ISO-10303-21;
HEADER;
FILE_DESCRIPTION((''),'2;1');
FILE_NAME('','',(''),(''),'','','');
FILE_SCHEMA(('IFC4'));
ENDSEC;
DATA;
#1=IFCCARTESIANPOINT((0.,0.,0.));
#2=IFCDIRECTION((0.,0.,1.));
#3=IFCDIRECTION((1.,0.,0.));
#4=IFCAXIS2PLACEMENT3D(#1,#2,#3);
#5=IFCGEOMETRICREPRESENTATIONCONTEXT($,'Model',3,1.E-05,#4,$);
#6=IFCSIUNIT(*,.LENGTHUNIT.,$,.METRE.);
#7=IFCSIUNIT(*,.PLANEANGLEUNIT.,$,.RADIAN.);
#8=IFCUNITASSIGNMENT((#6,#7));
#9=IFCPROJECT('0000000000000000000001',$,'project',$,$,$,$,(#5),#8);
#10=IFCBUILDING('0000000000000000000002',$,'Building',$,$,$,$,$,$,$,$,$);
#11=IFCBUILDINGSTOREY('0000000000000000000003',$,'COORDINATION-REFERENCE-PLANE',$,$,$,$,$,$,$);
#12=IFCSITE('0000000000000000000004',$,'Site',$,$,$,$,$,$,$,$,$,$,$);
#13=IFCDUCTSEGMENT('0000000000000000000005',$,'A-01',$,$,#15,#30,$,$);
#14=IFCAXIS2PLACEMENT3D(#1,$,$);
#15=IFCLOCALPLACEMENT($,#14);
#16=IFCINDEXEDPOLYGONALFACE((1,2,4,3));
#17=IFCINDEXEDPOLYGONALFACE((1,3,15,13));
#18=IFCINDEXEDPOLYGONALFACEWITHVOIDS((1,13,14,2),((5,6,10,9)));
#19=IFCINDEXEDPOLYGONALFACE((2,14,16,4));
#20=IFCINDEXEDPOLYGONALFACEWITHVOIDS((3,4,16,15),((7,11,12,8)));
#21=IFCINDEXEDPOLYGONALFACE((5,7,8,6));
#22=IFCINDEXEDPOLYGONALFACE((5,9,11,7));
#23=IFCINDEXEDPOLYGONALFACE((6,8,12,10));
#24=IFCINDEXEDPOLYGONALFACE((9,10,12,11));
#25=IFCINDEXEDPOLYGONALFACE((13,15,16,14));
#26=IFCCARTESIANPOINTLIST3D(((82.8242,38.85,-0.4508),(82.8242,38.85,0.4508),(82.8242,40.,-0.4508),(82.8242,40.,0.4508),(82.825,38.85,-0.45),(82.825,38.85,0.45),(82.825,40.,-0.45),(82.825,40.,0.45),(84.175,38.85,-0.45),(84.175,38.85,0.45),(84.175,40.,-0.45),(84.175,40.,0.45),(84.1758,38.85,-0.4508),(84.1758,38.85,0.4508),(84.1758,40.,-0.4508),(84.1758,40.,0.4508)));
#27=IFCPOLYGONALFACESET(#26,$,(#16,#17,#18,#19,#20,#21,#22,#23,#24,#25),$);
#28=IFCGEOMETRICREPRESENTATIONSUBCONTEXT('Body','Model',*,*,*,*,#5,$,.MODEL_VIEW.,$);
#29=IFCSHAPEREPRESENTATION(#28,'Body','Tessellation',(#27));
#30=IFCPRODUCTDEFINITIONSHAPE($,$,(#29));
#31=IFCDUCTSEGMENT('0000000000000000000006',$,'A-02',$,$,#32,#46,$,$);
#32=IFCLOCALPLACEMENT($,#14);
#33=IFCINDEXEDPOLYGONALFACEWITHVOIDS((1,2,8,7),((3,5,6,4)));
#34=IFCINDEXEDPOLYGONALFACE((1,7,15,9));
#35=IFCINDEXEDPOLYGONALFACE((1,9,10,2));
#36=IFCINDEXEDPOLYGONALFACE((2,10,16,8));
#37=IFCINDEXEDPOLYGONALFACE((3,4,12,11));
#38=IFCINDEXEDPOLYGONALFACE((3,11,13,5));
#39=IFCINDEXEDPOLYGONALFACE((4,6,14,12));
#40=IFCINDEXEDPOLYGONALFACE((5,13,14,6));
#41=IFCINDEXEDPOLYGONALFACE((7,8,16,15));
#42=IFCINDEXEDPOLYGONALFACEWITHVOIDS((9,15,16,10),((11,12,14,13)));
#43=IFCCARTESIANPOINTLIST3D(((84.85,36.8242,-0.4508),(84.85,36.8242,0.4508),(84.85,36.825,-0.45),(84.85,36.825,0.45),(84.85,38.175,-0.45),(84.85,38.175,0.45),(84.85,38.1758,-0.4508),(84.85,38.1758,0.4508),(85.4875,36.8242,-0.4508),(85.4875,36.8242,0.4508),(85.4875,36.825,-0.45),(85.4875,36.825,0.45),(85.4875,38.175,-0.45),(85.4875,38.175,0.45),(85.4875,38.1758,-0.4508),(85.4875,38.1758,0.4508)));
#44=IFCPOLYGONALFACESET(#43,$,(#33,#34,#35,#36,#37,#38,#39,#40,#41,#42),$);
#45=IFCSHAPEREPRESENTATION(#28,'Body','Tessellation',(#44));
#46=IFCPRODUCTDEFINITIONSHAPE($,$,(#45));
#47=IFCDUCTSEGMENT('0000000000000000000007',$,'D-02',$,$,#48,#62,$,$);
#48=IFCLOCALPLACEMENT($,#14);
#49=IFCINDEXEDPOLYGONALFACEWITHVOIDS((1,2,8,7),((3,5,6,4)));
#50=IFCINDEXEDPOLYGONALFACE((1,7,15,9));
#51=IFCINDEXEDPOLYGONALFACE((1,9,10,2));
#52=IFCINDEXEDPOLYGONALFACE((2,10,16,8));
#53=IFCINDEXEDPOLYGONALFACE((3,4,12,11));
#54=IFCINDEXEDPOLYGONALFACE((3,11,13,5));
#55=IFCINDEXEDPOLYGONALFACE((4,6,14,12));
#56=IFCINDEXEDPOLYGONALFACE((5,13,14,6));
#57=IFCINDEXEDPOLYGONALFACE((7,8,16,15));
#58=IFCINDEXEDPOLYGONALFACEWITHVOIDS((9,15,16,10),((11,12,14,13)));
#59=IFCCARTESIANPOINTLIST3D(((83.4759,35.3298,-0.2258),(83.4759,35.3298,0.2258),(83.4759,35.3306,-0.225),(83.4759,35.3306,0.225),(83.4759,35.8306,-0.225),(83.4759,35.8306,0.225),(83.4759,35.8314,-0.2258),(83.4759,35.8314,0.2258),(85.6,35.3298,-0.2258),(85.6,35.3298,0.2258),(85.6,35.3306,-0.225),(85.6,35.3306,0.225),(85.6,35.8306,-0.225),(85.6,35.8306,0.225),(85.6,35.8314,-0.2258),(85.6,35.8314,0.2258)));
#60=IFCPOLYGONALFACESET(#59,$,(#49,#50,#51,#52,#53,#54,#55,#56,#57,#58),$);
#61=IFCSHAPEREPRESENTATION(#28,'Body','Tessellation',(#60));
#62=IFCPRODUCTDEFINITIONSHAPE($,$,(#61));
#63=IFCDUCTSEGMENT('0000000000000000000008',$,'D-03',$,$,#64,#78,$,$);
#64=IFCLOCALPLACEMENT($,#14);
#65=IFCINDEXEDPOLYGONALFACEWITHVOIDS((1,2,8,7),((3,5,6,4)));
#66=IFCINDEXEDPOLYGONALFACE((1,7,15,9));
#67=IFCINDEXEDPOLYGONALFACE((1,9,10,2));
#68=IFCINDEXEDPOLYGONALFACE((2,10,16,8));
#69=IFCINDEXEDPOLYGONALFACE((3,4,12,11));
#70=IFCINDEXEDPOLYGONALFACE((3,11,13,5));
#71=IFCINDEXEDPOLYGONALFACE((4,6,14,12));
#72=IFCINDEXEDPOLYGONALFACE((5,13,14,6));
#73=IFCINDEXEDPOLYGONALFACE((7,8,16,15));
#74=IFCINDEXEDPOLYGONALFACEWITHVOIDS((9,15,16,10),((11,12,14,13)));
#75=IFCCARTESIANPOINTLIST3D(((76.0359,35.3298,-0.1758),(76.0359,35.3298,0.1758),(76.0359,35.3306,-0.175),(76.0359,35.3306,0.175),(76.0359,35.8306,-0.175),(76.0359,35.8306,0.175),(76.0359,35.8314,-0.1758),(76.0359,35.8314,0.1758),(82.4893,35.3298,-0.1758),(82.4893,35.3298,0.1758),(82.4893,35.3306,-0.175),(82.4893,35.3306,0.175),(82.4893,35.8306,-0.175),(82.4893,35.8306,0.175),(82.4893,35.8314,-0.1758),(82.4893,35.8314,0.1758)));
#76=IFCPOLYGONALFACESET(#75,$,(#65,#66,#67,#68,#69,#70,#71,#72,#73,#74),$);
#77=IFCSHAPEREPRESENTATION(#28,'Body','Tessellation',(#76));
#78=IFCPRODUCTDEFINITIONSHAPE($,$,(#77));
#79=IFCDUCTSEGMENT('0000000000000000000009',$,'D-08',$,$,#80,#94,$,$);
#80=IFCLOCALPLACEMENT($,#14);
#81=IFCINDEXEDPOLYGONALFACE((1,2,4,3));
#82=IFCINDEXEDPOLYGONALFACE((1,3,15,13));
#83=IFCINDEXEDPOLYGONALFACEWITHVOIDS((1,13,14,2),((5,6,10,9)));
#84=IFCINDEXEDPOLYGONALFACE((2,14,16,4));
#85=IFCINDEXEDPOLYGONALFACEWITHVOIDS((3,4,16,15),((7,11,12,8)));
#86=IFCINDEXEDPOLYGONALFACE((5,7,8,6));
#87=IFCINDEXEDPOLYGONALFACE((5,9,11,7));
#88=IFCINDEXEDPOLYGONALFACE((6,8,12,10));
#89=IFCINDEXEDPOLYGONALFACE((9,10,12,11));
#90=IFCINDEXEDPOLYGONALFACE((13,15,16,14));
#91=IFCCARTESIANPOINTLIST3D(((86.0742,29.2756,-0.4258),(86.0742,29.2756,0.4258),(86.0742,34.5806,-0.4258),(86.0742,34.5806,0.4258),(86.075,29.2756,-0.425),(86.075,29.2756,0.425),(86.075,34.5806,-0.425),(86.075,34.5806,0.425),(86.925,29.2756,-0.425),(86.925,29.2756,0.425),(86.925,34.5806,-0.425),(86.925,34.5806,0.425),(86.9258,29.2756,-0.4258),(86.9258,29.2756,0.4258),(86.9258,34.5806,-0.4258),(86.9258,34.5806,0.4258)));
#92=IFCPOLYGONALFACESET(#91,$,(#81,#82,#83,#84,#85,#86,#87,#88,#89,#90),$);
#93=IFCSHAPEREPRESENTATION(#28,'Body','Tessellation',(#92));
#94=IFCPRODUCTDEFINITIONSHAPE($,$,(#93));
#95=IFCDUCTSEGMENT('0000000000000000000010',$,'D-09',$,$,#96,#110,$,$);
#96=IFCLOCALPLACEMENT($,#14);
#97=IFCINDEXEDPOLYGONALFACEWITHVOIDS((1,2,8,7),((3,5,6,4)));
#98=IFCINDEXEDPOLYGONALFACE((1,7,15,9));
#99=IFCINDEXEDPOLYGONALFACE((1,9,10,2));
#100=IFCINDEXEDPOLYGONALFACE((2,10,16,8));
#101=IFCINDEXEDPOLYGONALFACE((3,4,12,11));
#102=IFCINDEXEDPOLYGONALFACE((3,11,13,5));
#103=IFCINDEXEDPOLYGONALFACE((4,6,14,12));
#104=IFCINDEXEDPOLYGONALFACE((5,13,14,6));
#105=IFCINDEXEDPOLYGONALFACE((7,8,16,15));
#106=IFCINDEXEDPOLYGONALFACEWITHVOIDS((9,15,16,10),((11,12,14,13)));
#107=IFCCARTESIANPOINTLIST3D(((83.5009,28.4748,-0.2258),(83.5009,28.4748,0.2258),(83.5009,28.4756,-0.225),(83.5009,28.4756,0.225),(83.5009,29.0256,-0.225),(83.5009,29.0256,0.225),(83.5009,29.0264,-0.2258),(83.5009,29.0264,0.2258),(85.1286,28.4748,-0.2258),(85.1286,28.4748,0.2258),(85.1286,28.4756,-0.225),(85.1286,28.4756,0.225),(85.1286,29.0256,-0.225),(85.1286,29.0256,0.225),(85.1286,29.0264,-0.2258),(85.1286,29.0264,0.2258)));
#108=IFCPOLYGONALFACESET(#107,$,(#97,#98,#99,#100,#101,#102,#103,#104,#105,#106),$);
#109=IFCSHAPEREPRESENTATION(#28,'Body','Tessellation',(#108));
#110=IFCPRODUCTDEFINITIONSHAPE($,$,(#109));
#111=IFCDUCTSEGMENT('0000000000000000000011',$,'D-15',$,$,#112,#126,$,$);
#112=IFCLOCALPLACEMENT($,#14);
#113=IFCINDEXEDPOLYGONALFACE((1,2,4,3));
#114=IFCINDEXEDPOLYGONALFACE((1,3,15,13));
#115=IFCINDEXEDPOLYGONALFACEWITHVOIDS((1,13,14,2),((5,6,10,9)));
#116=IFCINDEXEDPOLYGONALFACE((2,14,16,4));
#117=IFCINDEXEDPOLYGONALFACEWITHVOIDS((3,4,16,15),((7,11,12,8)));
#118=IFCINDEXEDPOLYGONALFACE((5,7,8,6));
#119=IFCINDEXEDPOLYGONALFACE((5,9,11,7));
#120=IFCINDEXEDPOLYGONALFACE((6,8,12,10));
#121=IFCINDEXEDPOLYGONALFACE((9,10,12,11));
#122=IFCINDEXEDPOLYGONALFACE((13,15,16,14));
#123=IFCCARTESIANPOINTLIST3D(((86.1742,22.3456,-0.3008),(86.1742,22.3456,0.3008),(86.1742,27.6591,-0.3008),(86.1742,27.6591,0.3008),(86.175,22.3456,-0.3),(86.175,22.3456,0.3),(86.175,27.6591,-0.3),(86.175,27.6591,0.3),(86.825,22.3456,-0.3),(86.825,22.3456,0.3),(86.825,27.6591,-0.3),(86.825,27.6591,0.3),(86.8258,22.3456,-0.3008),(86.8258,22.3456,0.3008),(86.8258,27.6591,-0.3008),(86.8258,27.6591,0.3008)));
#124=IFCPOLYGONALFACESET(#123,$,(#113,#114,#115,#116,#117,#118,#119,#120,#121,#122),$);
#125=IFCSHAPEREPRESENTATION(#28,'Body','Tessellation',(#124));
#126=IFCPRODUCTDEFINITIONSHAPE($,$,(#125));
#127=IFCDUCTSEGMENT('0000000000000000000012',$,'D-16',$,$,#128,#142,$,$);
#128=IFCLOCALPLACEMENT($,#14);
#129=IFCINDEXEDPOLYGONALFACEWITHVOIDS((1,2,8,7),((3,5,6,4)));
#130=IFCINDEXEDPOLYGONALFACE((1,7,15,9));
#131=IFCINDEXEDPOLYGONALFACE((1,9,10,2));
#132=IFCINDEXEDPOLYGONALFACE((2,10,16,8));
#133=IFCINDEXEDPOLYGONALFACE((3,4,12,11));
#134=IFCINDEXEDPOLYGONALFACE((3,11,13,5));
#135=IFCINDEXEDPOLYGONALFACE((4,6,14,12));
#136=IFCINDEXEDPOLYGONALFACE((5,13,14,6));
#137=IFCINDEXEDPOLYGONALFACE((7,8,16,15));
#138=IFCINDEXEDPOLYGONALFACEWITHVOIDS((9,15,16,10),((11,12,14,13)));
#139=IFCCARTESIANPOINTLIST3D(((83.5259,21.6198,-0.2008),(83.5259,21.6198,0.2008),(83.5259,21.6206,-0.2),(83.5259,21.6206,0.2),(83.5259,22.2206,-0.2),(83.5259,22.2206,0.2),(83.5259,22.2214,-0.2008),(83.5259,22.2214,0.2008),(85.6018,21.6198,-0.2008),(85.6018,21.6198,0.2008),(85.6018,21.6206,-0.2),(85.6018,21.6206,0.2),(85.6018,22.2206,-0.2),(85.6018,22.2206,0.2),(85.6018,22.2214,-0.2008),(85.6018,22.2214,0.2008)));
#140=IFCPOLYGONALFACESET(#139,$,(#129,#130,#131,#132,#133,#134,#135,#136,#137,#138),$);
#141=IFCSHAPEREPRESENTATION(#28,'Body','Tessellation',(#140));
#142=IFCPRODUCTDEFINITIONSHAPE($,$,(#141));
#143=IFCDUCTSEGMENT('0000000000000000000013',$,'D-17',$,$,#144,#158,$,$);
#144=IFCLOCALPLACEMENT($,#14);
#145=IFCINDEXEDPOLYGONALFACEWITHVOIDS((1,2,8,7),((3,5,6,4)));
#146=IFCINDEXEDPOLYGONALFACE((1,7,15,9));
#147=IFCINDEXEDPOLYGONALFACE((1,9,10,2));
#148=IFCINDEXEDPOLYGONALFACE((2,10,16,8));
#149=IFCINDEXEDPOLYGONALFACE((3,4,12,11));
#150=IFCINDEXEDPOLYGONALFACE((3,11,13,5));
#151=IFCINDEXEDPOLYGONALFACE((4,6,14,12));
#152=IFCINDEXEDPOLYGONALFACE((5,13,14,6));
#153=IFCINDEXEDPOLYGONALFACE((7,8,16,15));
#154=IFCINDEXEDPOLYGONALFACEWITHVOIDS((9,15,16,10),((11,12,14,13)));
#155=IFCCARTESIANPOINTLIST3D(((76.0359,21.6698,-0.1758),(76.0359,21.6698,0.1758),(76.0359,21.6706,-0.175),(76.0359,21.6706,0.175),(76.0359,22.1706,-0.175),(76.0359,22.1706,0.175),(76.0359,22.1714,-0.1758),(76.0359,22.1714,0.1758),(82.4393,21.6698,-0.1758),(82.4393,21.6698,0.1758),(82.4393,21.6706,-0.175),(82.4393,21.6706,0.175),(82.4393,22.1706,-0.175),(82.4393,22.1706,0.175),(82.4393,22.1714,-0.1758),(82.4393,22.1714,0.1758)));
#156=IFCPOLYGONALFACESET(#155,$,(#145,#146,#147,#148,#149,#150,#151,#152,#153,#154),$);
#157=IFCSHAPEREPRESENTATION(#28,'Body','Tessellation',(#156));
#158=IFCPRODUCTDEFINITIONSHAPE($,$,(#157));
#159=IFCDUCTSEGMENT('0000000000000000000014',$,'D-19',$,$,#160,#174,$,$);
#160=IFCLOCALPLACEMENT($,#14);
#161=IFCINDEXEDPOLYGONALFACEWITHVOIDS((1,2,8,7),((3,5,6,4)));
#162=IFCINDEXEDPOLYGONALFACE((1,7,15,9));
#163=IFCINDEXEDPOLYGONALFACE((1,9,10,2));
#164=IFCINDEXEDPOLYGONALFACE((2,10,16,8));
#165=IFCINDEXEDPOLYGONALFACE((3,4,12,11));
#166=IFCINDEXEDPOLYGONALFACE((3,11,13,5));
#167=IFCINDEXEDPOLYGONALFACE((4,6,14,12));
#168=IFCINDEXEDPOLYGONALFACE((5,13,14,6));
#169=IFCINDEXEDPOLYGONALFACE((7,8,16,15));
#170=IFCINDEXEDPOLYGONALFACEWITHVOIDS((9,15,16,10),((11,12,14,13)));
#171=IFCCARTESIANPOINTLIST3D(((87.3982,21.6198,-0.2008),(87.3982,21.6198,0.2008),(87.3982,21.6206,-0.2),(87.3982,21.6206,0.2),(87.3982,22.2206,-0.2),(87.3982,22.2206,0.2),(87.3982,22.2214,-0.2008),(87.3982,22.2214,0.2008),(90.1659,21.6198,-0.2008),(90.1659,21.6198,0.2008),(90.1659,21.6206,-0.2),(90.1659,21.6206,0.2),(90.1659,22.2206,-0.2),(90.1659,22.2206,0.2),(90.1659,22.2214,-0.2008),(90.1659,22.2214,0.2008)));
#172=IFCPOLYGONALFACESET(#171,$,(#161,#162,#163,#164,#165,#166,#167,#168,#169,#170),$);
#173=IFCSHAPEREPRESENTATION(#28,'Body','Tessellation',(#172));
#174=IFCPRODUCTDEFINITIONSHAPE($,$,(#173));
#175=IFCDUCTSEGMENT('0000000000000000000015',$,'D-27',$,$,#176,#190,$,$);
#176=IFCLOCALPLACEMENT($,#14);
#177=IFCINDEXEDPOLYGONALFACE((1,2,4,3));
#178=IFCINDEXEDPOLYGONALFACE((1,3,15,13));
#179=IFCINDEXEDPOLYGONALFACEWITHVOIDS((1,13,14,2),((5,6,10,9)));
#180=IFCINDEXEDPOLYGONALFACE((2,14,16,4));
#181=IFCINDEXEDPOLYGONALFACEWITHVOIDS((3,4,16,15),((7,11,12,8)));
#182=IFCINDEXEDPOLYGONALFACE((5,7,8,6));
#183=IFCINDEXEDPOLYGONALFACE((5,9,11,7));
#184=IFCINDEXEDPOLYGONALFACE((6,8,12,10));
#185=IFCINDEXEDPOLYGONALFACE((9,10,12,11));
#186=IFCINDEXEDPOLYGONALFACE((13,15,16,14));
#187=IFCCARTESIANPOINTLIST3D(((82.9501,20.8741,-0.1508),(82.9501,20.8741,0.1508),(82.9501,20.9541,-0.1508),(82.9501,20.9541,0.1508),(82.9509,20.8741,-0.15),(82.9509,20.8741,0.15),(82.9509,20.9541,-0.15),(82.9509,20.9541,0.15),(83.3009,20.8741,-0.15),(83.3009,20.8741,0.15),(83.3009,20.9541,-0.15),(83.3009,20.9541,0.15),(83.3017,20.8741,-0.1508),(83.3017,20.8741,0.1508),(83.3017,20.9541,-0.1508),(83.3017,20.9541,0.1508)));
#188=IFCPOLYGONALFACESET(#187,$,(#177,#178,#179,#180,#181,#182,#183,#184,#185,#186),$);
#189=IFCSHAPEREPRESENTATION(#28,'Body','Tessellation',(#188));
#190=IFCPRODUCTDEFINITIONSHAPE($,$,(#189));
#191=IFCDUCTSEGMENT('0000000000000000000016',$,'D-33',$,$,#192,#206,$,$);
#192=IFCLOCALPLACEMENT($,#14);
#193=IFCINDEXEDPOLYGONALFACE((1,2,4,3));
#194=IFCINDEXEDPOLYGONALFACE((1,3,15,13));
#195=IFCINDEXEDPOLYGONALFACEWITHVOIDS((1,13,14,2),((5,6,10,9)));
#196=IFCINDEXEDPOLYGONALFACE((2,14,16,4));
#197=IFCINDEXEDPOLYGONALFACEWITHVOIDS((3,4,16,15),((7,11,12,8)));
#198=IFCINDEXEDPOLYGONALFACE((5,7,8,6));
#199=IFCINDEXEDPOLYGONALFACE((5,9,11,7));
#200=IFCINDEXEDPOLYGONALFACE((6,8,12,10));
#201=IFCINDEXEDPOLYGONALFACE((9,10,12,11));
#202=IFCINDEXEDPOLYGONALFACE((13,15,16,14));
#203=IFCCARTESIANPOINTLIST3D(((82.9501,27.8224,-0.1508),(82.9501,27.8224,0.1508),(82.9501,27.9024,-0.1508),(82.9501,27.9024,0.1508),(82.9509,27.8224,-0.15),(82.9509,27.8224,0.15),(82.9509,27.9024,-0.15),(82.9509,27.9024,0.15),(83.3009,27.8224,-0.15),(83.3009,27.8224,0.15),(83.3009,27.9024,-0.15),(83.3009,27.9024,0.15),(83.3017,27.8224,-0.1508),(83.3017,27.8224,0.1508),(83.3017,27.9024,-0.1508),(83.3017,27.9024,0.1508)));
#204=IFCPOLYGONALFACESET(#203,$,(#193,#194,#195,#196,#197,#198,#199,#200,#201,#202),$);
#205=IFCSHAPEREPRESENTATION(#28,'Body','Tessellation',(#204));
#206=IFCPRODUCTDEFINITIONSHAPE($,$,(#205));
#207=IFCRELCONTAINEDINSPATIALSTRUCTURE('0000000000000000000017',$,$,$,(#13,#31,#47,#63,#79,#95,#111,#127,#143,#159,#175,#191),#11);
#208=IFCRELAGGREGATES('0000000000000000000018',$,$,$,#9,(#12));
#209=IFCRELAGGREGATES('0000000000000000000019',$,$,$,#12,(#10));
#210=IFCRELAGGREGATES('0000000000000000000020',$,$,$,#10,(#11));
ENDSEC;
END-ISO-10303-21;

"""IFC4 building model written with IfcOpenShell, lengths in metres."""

from ifc_helpers import new_model, si_unit, frame, origin, origin_with_axes, place, context, subcontext, project, spatial, hollow_rectangle, extrude, element, save


model = new_model("IFC4")

# Units and contexts
model_context = context("Model", 3, precision=1e-05, world=origin_with_axes())
body_context_1 = subcontext(model_context, "Body", "Model", "MODEL_VIEW")
ifc_project = project(units=[si_unit("LENGTHUNIT", "METRE"), si_unit("PLANEANGLEUNIT", "RADIAN")], contexts=[model_context])

# Site, building, storey
site = spatial("IfcSite", under=ifc_project, Name="Site")
building = spatial("IfcBuilding", under=site, Name="Building")
storey = spatial("IfcBuildingStorey", under=building, Name="COORDINATION-REFERENCE-PLANE")

# Duct segments
duct_segment_1_placement = place(None, frame((83.5, 38.85, 0.0), z_axis=(0.0, 1.0, 0.0), x_axis=(1.0, 0.0, 0.0)))
element("IfcDuctSegment", 1, at=duct_segment_1_placement, inside=storey, Name="A-01", context=body_context_1, shape_type="SweptSolid", body=[
    extrude(hollow_rectangle(XDim=1.3516, YDim=0.9016, WallThickness=0.0008), origin(), (0.0, 0.0, 1.0), 1.15),
])
duct_segment_2_placement = place(None, frame((84.85, 37.5, 0.0), z_axis=(1.0, 0.0, 0.0), x_axis=(0.0, 1.0, 0.0)))
element("IfcDuctSegment", 2, at=duct_segment_2_placement, inside=storey, Name="A-02", context=body_context_1, shape_type="SweptSolid", body=[
    extrude(hollow_rectangle(XDim=1.3516, YDim=0.9016, WallThickness=0.0008), origin(), (0.0, 0.0, 1.0), 0.6375),
])
duct_segment_3_placement = place(None, frame((83.4759, 35.5806, 0.0), z_axis=(1.0, 0.0, 0.0), x_axis=(0.0, 1.0, 0.0)))
element("IfcDuctSegment", 3, at=duct_segment_3_placement, inside=storey, Name="D-02", context=body_context_1, shape_type="SweptSolid", body=[
    extrude(hollow_rectangle(XDim=0.5016, YDim=0.4516, WallThickness=0.0008), origin(), (0.0, 0.0, 1.0), 2.1241),
])
duct_segment_4_placement = place(None, frame((76.0359, 35.5806, 0.0), z_axis=(1.0, 0.0, 0.0), x_axis=(0.0, 1.0, 0.0)))
element("IfcDuctSegment", 4, at=duct_segment_4_placement, inside=storey, Name="D-03", context=body_context_1, shape_type="SweptSolid", body=[
    extrude(hollow_rectangle(XDim=0.5016, YDim=0.3516, WallThickness=0.0008), origin(), (0.0, 0.0, 1.0), 6.4534),
])
duct_segment_5_placement = place(None, frame((86.5, 29.2756, 0.0), z_axis=(0.0, 1.0, 0.0), x_axis=(1.0, 0.0, 0.0)))
element("IfcDuctSegment", 5, at=duct_segment_5_placement, inside=storey, Name="D-08", context=body_context_1, shape_type="SweptSolid", body=[
    extrude(hollow_rectangle(XDim=0.8516, YDim=0.8516, WallThickness=0.0008), origin(), (0.0, 0.0, 1.0), 5.305),
])
duct_segment_6_placement = place(None, frame((83.5009, 28.7506, 0.0), z_axis=(1.0, 0.0, 0.0), x_axis=(0.0, 1.0, 0.0)))
element("IfcDuctSegment", 6, at=duct_segment_6_placement, inside=storey, Name="D-09", context=body_context_1, shape_type="SweptSolid", body=[
    extrude(hollow_rectangle(XDim=0.5516, YDim=0.4516, WallThickness=0.0008), origin(), (0.0, 0.0, 1.0), 1.6277),
])
duct_segment_7_placement = place(None, frame((86.5, 22.3456, 0.0), z_axis=(0.0, 1.0, 0.0), x_axis=(1.0, 0.0, 0.0)))
element("IfcDuctSegment", 7, at=duct_segment_7_placement, inside=storey, Name="D-15", context=body_context_1, shape_type="SweptSolid", body=[
    extrude(hollow_rectangle(XDim=0.6516, YDim=0.6016, WallThickness=0.0008), origin(), (0.0, 0.0, 1.0), 5.3135),
])
duct_segment_8_placement = place(None, frame((83.5259, 21.9206, 0.0), z_axis=(1.0, 0.0, 0.0), x_axis=(0.0, 1.0, 0.0)))
element("IfcDuctSegment", 8, at=duct_segment_8_placement, inside=storey, Name="D-16", context=body_context_1, shape_type="SweptSolid", body=[
    extrude(hollow_rectangle(XDim=0.6016, YDim=0.4016, WallThickness=0.0008), origin(), (0.0, 0.0, 1.0), 2.0759),
])
duct_segment_9_placement = place(None, frame((76.0359, 21.9206, 0.0), z_axis=(1.0, 0.0, 0.0), x_axis=(0.0, 1.0, 0.0)))
element("IfcDuctSegment", 9, at=duct_segment_9_placement, inside=storey, Name="D-17", context=body_context_1, shape_type="SweptSolid", body=[
    extrude(hollow_rectangle(XDim=0.5016, YDim=0.3516, WallThickness=0.0008), origin(), (0.0, 0.0, 1.0), 6.4034),
])
duct_segment_10_placement = place(None, frame((87.3982, 21.9206, 0.0), z_axis=(1.0, 0.0, 0.0), x_axis=(0.0, 1.0, 0.0)))
element("IfcDuctSegment", 10, at=duct_segment_10_placement, inside=storey, Name="D-19", context=body_context_1, shape_type="SweptSolid", body=[
    extrude(hollow_rectangle(XDim=0.6016, YDim=0.4016, WallThickness=0.0008), origin(), (0.0, 0.0, 1.0), 2.7677),
])
for number, where, z_axis, x_axis, name in (
    (11, (83.1259, 20.8741, 0.0), (0.0, 1.0, 0.0), (1.0, 0.0, 0.0), "D-27"),
    (12, (83.1259, 27.8224, 0.0), (0.0, 1.0, 0.0), (1.0, 0.0, 0.0), "D-33"),
):
    element("IfcDuctSegment", number, at=place(None, frame(where, z_axis=z_axis, x_axis=x_axis)), inside=storey, Name=name, context=body_context_1, shape_type="SweptSolid", body=[
        extrude(hollow_rectangle(XDim=0.3516, YDim=0.3016, WallThickness=0.0008), origin(), (0.0, 0.0, 1.0), 0.08),
    ])

save(model, "model.ifc")
